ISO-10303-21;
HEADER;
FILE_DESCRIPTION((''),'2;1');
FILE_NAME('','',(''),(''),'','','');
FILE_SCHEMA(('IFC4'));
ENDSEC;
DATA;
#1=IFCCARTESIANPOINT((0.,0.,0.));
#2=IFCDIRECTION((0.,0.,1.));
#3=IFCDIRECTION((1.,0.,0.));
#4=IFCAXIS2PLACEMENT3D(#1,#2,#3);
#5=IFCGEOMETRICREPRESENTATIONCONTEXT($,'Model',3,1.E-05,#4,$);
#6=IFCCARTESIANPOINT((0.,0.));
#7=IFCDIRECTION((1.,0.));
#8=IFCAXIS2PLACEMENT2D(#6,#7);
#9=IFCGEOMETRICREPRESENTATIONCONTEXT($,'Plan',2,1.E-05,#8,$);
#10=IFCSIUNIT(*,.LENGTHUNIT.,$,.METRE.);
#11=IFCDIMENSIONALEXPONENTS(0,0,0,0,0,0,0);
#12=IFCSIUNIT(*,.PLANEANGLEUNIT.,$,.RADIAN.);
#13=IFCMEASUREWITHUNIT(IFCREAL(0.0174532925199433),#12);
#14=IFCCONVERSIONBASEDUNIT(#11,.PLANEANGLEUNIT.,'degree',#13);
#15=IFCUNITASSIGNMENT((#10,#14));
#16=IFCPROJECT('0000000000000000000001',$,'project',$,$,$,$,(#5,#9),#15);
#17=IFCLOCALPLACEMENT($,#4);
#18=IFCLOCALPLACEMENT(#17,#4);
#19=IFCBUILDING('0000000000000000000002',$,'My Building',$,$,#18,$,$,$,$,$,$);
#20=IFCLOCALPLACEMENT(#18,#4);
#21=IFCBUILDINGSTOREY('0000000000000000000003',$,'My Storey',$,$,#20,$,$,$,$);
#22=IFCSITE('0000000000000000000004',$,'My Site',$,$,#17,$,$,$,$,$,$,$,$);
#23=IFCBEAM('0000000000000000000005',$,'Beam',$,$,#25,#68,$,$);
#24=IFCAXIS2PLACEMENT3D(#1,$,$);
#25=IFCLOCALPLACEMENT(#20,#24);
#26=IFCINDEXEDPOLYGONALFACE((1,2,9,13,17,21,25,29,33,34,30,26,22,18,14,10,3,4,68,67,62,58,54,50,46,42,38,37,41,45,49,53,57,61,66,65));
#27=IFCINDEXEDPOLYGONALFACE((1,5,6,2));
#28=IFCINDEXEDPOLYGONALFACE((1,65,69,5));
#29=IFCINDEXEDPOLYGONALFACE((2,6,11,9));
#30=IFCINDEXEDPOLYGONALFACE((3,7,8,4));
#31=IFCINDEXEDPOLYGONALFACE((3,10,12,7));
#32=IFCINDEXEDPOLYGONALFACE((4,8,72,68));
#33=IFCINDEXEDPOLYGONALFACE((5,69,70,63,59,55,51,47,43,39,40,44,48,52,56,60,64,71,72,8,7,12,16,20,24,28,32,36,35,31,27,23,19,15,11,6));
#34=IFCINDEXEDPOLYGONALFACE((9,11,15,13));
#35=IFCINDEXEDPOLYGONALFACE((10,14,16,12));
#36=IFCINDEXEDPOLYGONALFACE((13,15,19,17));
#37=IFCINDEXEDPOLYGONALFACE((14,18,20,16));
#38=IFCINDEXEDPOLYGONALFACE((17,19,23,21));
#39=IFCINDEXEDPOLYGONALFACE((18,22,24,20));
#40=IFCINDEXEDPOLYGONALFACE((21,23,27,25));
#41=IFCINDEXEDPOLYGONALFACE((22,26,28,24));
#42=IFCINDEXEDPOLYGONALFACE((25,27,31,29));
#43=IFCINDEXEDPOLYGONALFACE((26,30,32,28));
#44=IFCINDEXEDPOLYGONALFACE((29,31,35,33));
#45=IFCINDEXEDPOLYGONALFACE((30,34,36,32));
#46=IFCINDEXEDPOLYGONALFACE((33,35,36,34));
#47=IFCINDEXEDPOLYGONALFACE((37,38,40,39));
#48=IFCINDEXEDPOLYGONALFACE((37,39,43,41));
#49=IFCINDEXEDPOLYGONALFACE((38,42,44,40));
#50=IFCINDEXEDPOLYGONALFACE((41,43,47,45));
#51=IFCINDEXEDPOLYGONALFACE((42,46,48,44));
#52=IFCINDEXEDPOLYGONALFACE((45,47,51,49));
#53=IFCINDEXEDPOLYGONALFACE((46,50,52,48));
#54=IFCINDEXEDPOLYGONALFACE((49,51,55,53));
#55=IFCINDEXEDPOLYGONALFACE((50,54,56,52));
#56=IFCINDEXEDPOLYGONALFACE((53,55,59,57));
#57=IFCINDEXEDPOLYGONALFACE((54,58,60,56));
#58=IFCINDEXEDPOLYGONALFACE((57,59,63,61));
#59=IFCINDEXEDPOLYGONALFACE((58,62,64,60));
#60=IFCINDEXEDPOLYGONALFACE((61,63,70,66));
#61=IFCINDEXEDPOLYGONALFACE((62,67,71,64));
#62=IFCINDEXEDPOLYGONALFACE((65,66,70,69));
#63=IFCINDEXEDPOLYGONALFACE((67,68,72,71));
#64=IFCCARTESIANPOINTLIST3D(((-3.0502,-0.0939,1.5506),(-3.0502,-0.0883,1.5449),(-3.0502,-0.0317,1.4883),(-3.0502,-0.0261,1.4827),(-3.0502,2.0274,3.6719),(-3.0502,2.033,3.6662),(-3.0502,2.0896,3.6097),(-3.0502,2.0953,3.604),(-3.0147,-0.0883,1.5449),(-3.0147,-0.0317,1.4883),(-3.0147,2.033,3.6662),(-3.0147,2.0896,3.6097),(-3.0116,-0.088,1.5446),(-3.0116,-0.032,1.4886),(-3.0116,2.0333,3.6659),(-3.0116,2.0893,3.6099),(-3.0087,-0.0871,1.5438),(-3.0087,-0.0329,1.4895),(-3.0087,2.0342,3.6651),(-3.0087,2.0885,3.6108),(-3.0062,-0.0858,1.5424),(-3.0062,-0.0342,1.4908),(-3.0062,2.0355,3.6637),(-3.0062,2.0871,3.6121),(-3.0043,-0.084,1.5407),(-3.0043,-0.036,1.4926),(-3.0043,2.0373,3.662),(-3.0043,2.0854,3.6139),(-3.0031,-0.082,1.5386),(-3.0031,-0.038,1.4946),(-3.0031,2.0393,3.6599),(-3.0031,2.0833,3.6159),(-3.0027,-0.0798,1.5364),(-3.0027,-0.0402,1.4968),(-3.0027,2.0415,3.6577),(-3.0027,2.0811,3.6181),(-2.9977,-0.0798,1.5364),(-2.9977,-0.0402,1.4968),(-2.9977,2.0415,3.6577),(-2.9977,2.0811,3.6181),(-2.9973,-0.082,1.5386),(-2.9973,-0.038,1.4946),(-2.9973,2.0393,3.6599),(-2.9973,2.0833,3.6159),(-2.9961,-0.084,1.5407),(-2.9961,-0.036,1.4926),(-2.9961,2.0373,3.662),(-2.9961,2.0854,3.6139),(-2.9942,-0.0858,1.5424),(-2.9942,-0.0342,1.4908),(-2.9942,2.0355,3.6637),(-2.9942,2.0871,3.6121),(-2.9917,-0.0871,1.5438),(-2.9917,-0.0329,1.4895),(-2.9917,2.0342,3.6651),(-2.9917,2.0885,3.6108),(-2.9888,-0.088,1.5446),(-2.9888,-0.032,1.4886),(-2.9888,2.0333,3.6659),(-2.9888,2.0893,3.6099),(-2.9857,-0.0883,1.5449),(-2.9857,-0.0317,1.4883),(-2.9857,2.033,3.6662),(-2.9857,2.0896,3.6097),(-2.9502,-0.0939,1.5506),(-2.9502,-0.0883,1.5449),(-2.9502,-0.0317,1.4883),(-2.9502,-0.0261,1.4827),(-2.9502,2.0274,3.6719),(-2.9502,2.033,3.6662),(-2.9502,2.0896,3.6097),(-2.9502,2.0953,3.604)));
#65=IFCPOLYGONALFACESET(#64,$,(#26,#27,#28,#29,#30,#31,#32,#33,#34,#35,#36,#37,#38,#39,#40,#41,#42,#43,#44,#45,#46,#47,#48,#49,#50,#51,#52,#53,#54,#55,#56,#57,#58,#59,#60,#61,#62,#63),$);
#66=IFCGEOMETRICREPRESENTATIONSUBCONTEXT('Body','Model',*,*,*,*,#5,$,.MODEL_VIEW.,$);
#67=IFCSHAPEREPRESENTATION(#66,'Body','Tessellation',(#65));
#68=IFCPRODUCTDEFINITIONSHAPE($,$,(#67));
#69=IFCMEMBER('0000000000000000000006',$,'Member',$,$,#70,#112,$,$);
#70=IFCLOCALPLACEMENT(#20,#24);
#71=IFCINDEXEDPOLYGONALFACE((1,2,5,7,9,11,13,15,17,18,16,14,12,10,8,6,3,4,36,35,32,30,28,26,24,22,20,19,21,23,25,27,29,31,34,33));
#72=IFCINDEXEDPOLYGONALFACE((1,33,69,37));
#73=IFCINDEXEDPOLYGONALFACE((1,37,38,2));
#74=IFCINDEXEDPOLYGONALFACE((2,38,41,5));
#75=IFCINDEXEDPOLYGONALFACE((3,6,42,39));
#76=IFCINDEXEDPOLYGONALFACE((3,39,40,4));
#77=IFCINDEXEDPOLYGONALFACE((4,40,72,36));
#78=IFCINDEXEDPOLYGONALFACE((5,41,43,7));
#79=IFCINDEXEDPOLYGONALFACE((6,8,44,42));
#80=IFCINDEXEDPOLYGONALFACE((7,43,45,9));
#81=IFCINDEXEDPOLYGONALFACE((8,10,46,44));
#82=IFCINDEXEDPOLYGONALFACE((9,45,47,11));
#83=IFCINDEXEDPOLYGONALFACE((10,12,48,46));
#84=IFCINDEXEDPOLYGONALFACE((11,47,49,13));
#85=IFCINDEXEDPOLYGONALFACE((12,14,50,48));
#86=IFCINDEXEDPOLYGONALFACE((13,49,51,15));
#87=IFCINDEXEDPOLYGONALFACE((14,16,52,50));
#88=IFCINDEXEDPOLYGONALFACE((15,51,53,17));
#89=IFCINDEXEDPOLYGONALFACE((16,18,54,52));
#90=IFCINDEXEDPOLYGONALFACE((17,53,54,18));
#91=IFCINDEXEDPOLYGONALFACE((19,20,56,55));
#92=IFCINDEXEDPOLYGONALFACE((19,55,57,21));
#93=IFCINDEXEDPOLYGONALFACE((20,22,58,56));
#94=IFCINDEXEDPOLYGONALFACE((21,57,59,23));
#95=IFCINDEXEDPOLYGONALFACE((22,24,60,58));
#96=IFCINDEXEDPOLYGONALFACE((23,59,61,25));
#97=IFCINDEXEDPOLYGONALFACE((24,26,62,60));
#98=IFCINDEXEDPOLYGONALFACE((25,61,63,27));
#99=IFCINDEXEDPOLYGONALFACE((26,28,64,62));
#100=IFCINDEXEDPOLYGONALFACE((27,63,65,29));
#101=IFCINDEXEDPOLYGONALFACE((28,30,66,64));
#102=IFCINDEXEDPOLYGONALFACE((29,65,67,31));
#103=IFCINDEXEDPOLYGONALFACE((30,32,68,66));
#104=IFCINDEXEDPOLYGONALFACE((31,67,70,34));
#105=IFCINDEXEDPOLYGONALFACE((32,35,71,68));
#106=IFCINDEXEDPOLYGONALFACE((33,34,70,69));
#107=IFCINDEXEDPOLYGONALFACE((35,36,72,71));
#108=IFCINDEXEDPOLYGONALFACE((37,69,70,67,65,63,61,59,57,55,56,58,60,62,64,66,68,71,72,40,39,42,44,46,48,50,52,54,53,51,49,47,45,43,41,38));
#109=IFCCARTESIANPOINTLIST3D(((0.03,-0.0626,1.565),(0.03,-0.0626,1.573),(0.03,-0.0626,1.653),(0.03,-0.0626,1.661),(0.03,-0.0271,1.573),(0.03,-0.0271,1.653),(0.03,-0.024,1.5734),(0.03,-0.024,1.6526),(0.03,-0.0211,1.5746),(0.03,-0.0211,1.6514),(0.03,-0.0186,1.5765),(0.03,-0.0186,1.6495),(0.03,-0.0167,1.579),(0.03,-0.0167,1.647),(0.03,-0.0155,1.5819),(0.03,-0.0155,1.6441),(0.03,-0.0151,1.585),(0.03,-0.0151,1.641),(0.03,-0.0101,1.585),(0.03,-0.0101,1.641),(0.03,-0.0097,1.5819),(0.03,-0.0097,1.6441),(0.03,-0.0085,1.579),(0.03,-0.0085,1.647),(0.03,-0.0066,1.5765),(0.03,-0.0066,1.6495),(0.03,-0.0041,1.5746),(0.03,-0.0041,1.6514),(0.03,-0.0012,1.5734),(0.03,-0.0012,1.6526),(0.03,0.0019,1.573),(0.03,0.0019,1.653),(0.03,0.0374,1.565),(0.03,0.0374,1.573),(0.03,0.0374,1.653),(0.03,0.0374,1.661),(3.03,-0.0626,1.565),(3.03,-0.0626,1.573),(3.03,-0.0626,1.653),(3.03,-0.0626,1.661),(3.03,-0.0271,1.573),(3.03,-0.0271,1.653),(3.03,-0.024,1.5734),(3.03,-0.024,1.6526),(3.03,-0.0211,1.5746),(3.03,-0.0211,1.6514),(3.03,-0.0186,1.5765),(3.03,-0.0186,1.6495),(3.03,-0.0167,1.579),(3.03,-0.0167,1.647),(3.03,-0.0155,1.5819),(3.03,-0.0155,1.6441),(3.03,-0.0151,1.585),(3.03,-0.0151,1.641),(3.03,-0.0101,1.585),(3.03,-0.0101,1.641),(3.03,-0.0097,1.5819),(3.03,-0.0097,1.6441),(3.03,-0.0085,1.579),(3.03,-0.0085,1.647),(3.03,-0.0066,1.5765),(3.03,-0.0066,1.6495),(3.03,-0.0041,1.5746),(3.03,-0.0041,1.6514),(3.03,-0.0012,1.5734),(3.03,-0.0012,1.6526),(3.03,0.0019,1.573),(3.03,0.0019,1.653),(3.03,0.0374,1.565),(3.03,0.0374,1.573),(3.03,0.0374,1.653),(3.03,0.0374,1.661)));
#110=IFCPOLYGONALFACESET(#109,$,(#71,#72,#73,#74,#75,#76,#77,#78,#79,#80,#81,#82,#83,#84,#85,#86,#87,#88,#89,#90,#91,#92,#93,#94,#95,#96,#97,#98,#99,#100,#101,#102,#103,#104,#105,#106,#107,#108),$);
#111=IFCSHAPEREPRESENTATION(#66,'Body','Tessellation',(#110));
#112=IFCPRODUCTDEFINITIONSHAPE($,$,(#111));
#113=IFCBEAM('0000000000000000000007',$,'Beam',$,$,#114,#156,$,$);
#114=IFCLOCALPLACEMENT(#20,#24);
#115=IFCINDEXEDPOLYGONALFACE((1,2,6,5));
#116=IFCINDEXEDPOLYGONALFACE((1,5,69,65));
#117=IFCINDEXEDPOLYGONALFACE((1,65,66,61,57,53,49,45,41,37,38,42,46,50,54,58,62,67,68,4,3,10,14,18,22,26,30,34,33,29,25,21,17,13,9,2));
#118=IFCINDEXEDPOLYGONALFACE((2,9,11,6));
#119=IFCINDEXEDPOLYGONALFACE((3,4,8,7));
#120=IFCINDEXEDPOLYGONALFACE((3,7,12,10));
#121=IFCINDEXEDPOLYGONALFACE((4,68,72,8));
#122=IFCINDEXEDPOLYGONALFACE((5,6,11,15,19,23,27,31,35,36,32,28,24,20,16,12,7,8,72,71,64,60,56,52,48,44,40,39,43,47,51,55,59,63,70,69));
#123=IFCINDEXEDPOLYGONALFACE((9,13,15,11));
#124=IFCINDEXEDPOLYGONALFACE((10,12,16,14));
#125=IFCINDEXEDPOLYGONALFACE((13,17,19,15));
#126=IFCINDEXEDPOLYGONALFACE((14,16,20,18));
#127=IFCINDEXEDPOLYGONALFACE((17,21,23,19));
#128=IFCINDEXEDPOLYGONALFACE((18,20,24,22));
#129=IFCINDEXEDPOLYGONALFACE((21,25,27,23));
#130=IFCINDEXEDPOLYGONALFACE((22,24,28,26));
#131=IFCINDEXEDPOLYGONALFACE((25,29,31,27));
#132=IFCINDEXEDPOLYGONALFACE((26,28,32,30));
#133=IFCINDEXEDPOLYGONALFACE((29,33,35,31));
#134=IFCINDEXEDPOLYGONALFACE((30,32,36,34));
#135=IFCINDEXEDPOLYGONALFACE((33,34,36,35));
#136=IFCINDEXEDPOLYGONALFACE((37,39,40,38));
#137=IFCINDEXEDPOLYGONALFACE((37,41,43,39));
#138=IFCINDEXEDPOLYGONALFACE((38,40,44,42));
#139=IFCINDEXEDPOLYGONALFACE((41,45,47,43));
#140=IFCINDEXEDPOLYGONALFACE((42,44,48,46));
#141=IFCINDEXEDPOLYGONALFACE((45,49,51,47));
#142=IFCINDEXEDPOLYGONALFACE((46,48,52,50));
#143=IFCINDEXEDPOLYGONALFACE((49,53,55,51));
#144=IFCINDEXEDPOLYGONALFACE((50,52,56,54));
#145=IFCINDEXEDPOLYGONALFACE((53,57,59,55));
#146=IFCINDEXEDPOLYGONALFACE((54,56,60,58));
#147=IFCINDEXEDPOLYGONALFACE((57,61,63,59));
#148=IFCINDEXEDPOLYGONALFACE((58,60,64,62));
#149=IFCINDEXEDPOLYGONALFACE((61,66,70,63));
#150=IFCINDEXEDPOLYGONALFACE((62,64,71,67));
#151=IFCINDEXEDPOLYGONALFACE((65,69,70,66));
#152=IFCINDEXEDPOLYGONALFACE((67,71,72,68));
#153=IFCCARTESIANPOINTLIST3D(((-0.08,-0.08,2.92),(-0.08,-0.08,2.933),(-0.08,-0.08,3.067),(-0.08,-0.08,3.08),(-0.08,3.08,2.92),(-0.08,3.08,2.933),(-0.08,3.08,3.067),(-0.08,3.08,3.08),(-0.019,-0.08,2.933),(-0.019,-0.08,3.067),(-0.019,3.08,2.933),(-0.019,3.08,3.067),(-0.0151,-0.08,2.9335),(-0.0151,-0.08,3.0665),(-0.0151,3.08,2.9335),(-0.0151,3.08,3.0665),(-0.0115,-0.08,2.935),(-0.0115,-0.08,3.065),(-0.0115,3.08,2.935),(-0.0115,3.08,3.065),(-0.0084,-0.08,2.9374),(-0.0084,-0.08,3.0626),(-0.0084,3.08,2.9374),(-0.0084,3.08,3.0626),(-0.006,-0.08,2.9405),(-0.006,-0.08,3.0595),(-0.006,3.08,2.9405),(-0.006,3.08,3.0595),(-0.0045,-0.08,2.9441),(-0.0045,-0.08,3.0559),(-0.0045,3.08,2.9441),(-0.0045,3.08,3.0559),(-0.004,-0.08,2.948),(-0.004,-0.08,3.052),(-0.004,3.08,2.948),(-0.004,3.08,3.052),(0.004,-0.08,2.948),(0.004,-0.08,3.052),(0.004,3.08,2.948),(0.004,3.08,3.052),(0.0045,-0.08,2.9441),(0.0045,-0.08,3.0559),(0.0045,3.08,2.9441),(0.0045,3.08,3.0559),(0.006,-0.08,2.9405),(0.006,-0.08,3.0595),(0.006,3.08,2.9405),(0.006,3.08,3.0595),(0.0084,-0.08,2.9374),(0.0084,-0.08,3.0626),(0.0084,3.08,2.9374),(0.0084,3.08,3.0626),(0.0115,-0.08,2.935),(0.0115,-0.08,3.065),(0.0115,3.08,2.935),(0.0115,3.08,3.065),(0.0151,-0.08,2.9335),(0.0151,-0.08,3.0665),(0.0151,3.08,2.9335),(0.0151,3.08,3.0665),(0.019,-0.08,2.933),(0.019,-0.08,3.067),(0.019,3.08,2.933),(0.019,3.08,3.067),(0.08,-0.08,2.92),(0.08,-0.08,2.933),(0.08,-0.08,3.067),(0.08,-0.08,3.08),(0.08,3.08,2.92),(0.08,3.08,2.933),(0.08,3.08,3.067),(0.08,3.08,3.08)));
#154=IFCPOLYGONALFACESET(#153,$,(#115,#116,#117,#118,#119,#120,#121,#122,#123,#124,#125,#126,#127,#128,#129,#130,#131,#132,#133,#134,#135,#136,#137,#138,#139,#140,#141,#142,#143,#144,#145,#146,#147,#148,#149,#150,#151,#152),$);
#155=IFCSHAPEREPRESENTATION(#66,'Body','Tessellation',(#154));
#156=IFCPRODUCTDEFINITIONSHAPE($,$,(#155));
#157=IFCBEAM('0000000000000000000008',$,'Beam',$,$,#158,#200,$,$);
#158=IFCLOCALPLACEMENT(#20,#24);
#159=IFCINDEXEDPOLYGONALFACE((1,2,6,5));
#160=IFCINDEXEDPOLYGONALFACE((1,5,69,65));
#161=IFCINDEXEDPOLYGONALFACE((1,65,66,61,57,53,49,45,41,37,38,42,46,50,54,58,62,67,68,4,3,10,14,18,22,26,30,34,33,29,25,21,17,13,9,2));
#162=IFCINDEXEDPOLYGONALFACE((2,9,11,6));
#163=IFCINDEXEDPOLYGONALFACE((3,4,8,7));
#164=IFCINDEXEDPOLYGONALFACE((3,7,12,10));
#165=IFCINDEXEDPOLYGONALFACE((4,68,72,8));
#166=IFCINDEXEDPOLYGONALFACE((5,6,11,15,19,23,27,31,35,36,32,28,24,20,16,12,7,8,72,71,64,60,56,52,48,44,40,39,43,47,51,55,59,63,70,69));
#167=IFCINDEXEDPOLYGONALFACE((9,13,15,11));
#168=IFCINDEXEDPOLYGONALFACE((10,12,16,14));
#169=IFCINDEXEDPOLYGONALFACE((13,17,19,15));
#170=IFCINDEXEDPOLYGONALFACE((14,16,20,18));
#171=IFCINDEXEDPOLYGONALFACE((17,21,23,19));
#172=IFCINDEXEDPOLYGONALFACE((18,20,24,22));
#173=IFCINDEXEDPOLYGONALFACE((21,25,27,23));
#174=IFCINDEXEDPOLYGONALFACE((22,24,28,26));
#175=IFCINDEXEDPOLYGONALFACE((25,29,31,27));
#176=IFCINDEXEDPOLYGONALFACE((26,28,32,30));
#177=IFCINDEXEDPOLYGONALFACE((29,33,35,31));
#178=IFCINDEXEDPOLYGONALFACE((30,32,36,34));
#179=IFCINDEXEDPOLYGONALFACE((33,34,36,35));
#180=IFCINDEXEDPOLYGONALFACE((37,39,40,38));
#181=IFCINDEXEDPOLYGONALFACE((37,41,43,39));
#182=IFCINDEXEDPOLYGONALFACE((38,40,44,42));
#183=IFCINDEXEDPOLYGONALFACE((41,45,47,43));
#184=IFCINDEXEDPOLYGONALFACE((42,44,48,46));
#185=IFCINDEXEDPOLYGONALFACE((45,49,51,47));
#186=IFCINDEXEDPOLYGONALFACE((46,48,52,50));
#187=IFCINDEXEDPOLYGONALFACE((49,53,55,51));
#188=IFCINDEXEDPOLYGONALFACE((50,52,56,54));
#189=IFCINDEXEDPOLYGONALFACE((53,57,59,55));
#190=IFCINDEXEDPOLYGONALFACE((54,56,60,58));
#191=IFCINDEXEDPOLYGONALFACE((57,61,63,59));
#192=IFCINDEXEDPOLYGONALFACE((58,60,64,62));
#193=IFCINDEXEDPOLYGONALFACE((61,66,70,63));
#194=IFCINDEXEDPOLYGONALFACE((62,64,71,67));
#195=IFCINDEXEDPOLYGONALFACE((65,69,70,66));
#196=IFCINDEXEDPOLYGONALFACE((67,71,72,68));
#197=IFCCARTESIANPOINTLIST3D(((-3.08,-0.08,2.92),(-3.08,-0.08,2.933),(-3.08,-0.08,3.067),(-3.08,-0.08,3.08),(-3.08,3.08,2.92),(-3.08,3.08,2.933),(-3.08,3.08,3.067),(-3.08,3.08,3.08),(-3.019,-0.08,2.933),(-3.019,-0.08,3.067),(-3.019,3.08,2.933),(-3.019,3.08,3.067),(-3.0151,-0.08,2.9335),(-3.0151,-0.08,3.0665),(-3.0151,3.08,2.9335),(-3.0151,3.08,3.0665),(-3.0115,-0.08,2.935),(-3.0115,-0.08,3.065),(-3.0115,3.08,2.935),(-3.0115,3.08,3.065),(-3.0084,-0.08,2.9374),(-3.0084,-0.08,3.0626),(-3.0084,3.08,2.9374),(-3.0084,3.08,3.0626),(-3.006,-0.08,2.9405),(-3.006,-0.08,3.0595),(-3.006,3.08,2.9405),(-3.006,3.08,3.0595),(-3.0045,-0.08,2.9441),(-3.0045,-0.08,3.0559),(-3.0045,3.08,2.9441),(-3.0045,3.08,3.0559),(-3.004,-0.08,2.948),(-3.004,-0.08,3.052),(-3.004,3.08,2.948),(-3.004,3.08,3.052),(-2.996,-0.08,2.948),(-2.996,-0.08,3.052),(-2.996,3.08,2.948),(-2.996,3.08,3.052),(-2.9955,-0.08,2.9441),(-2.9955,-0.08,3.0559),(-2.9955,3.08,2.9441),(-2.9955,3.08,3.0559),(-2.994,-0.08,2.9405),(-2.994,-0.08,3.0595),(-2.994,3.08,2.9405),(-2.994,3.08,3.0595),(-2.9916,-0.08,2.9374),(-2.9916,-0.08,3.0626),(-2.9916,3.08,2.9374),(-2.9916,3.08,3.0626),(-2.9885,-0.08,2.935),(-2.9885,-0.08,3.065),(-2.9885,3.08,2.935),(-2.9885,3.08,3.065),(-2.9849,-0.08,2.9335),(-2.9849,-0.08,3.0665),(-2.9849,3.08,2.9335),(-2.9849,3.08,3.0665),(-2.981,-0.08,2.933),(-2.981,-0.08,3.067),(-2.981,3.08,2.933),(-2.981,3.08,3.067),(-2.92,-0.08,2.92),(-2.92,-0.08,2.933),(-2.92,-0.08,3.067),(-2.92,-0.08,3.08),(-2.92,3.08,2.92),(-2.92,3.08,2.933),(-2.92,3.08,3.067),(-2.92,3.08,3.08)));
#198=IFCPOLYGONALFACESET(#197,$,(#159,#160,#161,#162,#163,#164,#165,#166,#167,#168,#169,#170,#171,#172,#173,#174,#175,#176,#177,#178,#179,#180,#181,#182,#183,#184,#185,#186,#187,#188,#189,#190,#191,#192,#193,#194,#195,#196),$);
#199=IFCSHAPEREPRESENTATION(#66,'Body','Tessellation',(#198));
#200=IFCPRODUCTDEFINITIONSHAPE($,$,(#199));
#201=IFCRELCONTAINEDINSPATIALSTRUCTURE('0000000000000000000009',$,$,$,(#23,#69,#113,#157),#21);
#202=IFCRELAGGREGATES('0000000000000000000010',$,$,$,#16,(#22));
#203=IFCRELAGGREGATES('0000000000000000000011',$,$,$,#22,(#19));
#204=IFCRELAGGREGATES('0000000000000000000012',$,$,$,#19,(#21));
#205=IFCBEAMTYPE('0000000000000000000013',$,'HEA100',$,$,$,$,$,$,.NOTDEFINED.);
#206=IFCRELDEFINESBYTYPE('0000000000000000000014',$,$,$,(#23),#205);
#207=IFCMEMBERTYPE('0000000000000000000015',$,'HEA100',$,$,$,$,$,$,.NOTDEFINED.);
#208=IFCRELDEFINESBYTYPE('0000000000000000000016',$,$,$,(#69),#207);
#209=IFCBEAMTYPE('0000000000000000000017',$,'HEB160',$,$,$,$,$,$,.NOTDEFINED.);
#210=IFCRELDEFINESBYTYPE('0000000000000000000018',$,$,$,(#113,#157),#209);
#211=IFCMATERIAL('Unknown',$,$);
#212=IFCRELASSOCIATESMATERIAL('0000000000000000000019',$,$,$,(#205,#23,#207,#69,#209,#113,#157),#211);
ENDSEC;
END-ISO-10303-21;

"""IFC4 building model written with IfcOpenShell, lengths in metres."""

from ifc_helpers import new_model, entity, si_unit, converted_unit, frame, origin_with_axes, origin_2d_with_axis, place, context, subcontext, project, spatial, i_section, extrude, material, material_profile, profile_set, profile_usage, type_object, element, save


model = new_model("IFC4")

# Units and contexts
model_context = context("Model", 3, precision=1e-05, world=origin_with_axes())
plan_context = context("Plan", 2, precision=1e-05, world=origin_2d_with_axis())
body_context = subcontext(model_context, "Body", "Model", "MODEL_VIEW")
ifc_project = project(units=[si_unit("LENGTHUNIT", "METRE"), converted_unit("PLANEANGLEUNIT", "degree", entity("IfcReal", 0.0174532925199433), si_unit("PLANEANGLEUNIT", "RADIAN"), dimensions=[0, 0, 0, 0, 0, 0, 0])], contexts=[model_context, plan_context])

# Site, building, storey
site_placement = place(None, origin_with_axes())
site = spatial("IfcSite", under=ifc_project, at=site_placement, Name="My Site")
building_placement = place(site_placement, origin_with_axes())
building = spatial("IfcBuilding", under=site, at=building_placement, Name="My Building")
storey_placement = place(building_placement, origin_with_axes())
storey = spatial("IfcBuildingStorey", under=building, at=storey_placement, Name="My Storey")

# Shared definitions
ifc_material = material(Name="Unknown")

# Beam
ifc_material_profile_1 = material_profile(ifc_material, i_section(OverallWidth=0.1, OverallDepth=0.096, WebThickness=0.005, FlangeThickness=0.008, FilletRadius=0.012))
ifc_profile_set_1 = profile_set([ifc_material_profile_1])
beam_type_1 = type_object("IfcBeamType", Name="HEA100", PredefinedType="NOTDEFINED", material=ifc_profile_set_1)
ifc_profile_usage_1 = profile_usage(ifc_profile_set_1, cardinal=5)
beam_1_placement = place(storey_placement, frame((-3.0002, -0.06, 1.5166), z_axis=(0.0, 0.707107, 0.707107), x_axis=(1.0, 0.0, 0.0)))
element("IfcBeam", 1, at=beam_1_placement, inside=storey, type_object=beam_type_1, material=ifc_profile_usage_1, Name="Beam", context=body_context, shape_type="SweptSolid", body=[
    extrude(i_section(OverallWidth=0.1, OverallDepth=0.096, WebThickness=0.005, FlangeThickness=0.008, FilletRadius=0.012), origin_with_axes(), (0.0, 0.0, 1.0), 3.0),
])

# Member
ifc_material_profile_2 = material_profile(ifc_material, i_section(OverallWidth=0.1, OverallDepth=0.096, WebThickness=0.005, FlangeThickness=0.008, FilletRadius=0.012))
ifc_profile_set_2 = profile_set([ifc_material_profile_2])
ifc_profile_usage_2 = profile_usage(ifc_profile_set_2, cardinal=5)
member_type = type_object("IfcMemberType", Name="HEA100", PredefinedType="NOTDEFINED", material=ifc_profile_set_2)
member_placement = place(storey_placement, frame((0.03, -0.0126, 1.613), z_axis=(1.0, 0.0, 0.0), x_axis=(0.0, 1.0, 0.0)))
element("IfcMember", 2, at=member_placement, inside=storey, type_object=member_type, material=ifc_profile_usage_2, Name="Member", context=body_context, shape_type="SweptSolid", body=[
    extrude(i_section(OverallWidth=0.1, OverallDepth=0.096, WebThickness=0.005, FlangeThickness=0.008, FilletRadius=0.012), origin_with_axes(), (0.0, 0.0, 1.0), 3.0),
])

# Beams
ifc_material_profile_3 = material_profile(ifc_material, i_section(OverallWidth=0.16, OverallDepth=0.16, WebThickness=0.008, FlangeThickness=0.013, FilletRadius=0.015))
ifc_profile_set_3 = profile_set([ifc_material_profile_3])
ifc_profile_usage_3 = profile_usage(ifc_profile_set_3, cardinal=5)
beam_type_2 = type_object("IfcBeamType", Name="HEB160", PredefinedType="NOTDEFINED", material=ifc_profile_set_3)
beam_2_placement = place(storey_placement, frame((0.0, -0.08, 3.0), z_axis=(0.0, 1.0, 0.0), x_axis=(-1.0, 0.0, 0.0)))
element("IfcBeam", 3, at=beam_2_placement, inside=storey, type_object=beam_type_2, material=ifc_profile_usage_3, Name="Beam", context=body_context, shape_type="SweptSolid", body=[
    extrude(i_section(OverallWidth=0.16, OverallDepth=0.16, WebThickness=0.008, FlangeThickness=0.013, FilletRadius=0.015), origin_with_axes(), (0.0, 0.0, 1.0), 3.16),
])
ifc_profile_usage_4 = profile_usage(ifc_profile_set_3, cardinal=5)
beam_3_placement = place(storey_placement, frame((-3.0, -0.08, 3.0), z_axis=(0.0, 1.0, 0.0), x_axis=(-1.0, 0.0, 0.0)))
element("IfcBeam", 4, at=beam_3_placement, inside=storey, type_object=beam_type_2, material=ifc_profile_usage_4, Name="Beam", context=body_context, shape_type="SweptSolid", body=[
    extrude(i_section(OverallWidth=0.16, OverallDepth=0.16, WebThickness=0.008, FlangeThickness=0.013, FilletRadius=0.015), origin_with_axes(), (0.0, 0.0, 1.0), 3.16),
])

save(model, "model.ifc")
